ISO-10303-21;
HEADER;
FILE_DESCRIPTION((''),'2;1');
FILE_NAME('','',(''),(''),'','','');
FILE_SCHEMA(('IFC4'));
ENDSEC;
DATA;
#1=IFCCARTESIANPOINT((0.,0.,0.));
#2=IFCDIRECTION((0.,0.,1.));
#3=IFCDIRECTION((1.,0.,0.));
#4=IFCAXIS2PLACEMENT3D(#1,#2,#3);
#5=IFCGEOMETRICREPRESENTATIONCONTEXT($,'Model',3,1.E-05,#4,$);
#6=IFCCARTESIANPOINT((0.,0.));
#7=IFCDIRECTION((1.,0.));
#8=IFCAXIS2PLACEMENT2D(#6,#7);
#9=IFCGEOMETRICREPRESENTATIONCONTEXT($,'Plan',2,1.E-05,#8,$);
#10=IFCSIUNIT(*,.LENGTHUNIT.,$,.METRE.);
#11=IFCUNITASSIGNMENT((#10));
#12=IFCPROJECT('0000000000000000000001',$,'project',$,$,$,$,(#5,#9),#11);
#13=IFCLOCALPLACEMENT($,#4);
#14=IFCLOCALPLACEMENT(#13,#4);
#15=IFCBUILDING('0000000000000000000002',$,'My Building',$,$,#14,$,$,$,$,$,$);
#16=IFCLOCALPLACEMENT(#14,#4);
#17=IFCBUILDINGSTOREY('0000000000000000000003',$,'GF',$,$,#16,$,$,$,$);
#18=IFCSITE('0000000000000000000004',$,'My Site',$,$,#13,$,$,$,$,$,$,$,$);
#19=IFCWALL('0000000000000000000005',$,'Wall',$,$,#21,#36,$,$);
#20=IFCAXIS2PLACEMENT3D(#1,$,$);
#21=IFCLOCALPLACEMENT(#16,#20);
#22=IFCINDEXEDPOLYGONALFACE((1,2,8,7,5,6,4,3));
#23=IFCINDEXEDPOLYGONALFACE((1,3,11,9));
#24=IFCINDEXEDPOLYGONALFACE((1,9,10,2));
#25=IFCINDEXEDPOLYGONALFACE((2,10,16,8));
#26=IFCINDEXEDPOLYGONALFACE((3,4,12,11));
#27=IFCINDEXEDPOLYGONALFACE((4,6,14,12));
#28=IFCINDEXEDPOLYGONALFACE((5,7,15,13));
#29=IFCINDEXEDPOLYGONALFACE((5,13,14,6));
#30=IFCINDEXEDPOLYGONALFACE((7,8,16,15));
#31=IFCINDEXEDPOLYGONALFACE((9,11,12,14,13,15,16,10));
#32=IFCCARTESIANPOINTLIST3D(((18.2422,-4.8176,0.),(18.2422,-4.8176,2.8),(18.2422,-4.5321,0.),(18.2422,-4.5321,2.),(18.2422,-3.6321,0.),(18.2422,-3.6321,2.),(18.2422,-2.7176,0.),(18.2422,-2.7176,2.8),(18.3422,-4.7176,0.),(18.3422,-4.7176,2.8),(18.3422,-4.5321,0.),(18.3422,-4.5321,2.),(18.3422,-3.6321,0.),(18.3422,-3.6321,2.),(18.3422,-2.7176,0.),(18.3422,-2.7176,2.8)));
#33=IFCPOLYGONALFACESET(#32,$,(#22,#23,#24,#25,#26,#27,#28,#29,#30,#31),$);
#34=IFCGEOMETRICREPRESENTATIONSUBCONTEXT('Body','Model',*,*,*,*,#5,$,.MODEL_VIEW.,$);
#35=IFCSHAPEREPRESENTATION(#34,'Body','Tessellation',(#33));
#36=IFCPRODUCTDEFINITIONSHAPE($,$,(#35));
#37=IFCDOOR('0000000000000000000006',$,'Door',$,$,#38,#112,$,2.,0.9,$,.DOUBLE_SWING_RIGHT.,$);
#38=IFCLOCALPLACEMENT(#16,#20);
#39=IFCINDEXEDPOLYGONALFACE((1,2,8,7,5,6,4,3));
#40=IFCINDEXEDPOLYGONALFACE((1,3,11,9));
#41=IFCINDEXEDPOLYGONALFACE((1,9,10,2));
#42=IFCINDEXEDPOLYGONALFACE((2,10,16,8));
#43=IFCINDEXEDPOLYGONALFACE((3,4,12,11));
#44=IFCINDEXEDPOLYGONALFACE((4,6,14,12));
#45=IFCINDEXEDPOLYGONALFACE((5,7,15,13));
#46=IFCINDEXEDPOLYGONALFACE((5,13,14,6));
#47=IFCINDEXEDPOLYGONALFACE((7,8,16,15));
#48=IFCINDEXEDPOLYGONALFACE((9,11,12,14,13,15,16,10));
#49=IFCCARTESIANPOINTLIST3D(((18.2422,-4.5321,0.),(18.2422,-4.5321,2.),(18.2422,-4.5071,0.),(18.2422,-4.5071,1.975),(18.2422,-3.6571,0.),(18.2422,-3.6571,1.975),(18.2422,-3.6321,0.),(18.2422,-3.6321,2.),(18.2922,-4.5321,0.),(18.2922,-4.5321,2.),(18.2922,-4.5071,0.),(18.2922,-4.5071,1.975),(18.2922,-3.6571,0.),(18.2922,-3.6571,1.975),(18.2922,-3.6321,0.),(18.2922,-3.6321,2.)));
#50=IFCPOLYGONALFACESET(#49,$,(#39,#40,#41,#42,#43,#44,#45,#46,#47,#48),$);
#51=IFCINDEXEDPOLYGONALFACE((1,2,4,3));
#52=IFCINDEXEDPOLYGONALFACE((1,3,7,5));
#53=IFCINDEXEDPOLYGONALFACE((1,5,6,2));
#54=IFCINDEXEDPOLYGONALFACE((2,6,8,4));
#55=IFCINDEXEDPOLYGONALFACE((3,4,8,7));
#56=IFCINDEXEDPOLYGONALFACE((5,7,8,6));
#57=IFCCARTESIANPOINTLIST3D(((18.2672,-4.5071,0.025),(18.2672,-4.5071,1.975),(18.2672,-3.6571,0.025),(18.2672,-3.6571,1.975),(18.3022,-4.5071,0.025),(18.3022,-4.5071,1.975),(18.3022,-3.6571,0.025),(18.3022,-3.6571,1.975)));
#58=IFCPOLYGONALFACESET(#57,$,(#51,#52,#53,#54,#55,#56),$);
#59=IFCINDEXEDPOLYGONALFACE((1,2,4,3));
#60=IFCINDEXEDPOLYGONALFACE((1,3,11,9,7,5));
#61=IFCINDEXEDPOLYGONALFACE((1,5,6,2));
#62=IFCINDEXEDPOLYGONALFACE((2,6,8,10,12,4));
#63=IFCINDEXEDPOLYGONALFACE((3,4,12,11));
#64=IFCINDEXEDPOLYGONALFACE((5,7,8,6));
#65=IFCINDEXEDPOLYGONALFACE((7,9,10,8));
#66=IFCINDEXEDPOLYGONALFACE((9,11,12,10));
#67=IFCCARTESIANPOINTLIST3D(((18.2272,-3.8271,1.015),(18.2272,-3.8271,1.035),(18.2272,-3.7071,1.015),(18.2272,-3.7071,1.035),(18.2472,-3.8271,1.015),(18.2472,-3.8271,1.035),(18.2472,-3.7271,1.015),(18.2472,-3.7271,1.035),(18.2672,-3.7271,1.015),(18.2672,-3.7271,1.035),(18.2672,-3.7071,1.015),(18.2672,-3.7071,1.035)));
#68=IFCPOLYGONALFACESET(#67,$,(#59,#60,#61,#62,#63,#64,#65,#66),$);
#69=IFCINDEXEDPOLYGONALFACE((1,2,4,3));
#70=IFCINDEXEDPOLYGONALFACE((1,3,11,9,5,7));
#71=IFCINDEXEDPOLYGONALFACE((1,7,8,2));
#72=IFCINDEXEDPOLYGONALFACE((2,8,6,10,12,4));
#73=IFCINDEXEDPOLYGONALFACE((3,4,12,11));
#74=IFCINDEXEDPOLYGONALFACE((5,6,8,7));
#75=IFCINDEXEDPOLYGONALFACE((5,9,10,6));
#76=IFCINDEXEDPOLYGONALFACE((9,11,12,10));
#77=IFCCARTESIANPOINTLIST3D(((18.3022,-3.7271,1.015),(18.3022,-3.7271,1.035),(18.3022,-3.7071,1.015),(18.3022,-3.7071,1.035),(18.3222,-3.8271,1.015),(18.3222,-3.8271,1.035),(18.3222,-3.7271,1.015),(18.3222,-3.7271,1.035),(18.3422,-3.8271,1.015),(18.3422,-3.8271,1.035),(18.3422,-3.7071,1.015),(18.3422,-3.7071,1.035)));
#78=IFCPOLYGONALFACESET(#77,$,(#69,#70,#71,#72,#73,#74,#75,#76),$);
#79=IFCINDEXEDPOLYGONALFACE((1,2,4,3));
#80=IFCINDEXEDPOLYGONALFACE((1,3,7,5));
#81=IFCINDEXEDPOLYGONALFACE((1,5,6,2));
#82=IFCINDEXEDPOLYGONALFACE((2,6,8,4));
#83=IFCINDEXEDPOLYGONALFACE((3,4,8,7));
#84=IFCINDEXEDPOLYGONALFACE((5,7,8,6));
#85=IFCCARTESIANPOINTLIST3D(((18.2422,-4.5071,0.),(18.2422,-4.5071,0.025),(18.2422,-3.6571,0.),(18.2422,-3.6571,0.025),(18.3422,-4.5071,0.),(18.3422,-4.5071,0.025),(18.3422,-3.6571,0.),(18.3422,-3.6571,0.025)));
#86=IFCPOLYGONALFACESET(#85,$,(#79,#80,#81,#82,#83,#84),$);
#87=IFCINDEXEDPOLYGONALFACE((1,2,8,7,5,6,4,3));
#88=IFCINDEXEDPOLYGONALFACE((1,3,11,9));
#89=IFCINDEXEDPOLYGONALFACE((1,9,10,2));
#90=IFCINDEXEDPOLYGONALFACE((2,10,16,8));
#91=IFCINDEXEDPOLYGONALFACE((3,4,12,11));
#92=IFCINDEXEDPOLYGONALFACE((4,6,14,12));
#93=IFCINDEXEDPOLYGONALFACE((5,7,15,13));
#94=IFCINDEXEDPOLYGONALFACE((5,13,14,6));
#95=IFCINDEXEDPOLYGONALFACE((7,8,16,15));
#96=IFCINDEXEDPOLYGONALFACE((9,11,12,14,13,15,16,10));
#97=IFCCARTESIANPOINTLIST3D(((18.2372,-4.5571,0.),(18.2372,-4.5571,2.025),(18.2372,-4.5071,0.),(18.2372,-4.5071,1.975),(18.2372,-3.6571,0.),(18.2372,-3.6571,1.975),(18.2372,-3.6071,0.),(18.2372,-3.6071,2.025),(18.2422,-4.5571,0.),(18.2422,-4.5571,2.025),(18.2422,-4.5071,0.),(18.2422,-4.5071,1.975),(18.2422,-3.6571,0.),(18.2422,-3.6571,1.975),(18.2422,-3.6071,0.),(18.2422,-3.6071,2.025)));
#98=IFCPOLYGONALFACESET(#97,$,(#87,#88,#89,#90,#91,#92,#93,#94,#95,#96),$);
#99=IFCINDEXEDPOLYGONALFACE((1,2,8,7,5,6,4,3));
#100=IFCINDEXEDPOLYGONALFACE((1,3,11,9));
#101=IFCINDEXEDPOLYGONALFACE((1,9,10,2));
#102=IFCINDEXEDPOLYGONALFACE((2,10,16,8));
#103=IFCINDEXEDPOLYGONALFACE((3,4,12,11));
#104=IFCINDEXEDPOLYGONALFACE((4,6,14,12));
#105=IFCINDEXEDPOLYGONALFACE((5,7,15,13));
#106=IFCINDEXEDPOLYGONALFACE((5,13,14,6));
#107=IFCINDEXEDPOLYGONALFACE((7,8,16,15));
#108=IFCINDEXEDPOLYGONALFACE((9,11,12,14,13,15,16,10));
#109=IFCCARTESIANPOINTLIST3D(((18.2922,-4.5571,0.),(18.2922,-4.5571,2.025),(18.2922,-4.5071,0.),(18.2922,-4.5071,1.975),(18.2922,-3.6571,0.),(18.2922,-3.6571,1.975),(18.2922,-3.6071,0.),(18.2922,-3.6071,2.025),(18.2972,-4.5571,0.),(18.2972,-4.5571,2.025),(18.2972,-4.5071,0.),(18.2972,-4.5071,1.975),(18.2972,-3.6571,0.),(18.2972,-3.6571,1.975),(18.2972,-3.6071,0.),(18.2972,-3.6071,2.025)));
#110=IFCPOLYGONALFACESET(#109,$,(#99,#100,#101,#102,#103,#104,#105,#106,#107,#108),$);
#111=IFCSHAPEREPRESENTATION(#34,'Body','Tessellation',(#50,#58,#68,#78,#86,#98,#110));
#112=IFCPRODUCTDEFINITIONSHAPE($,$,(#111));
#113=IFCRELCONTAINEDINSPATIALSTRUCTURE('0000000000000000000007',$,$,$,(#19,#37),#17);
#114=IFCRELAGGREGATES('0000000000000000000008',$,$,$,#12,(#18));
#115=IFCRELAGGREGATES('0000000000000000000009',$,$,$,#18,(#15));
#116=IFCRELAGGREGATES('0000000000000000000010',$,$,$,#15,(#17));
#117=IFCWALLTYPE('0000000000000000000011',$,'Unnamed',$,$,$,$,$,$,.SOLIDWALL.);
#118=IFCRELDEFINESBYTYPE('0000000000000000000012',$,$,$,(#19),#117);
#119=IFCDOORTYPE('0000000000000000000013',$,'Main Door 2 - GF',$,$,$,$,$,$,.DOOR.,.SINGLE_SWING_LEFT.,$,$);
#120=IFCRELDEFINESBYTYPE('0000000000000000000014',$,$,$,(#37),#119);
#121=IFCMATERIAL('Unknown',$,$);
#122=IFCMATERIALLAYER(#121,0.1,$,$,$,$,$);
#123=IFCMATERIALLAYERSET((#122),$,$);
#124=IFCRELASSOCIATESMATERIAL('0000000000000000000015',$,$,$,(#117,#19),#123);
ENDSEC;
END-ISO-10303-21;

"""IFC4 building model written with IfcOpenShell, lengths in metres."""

from ifc_helpers import new_model, entity, si_unit, frame, origin_with_axes, origin_2d_with_axis, place, context, subcontext, project, spatial, line, indexed_curve, outline, extrude, shape, source, transform, mapped, material, layer, layer_set, layer_usage, type_object, type_shapes, element, fill, save


model = new_model("IFC4")

# Units and contexts
model_context = context("Model", 3, precision=1e-05, world=origin_with_axes())
plan_context = context("Plan", 2, precision=1e-05, world=origin_2d_with_axis())
body_context_1 = subcontext(model_context, "Body", "Model", "MODEL_VIEW")
body_context_2 = subcontext(plan_context, "Body", "Plan", "PLAN_VIEW")
ifc_project = project(units=[si_unit("LENGTHUNIT", "METRE")], contexts=[model_context, plan_context])

# Site, building, storey
site_placement = place(None, origin_with_axes())
site = spatial("IfcSite", under=ifc_project, at=site_placement, Name="My Site")
building_placement = place(site_placement, origin_with_axes())
building = spatial("IfcBuilding", under=site, at=building_placement, Name="My Building")
storey_placement = place(building_placement, origin_with_axes())
storey = spatial("IfcBuildingStorey", under=building, at=storey_placement, Name="GF")

# Shared definitions
ifc_material = material(Name="Unknown")

# Shared definitions
ifc_layer_1 = layer(ifc_material, 0.1)
ifc_layer_set_1 = layer_set([ifc_layer_1])
wall_type = type_object("IfcWallType", Name="Unnamed", PredefinedType="SOLIDWALL", material=ifc_layer_set_1)

# Wall, opening, door
ifc_layer_usage_1 = layer_usage(ifc_layer_set_1, "AXIS2", "POSITIVE", 0.0)
wall_1_placement = place(storey_placement, frame((18.3422, -4.7176, 0.0), z_axis=(0.0, 0.0, 1.0), x_axis=(0.0, 1.0, 0.0)))
wall_1 = element("IfcWall", 1, at=wall_1_placement, inside=storey, type_object=wall_type, material=ifc_layer_usage_1, Name="Wall", context=body_context_1, shape_type="SweptSolid", body=[
    extrude(outline(indexed_curve([(0.0, 0.0), (-0.1, 0.1), (2.0, 0.1), (2.0, 0.0)], segments=[line(1, 2, 3, 4, 1)])), origin_with_axes(), (0.0, 0.0, 1.0), 2.8),
])
shared_shape_1 = source(origin_with_axes(), body_context_1, "Body", "SweptSolid", [
    extrude(outline(indexed_curve([(0.0, 0.0), (0.9, 0.0), (0.9, 2.0), (0.0, 2.0)], segments=[line(1, 2, 3, 4, 1)])), frame((0.0, -0.6, 0.0), z_axis=(0.0, -1.0, 0.0), x_axis=(1.0, 0.0, 0.0)), (0.0, 0.0, -1.0), 1.2),
])
opening_1_placement = place(wall_1_placement, frame((1.0855, 0.1, 0.0), z_axis=(0.0, 0.0, 1.0), x_axis=(-1.0, 0.0, 0.0)))
opening_1 = element("IfcOpeningElement", 2, at=opening_1_placement, cuts=wall_1, PredefinedType="OPENING", context=body_context_1, shape_type="MappedRepresentation", body=[
    mapped(shared_shape_1, transform((0.0, 0.0, 0.0), x_axis=(1.0, 0.0, 0.0), y_axis=(0.0, 1.0, 0.0), z_axis=(0.0, 0.0, 1.0), scale=1.0)),
])
door_type_1 = type_object("IfcDoorType", Name="Main Door 2 - GF", OperationType="SINGLE_SWING_LEFT", PredefinedType="DOOR")
shared_shape_2 = source(origin_with_axes(), body_context_1, "Body", "SweptSolid", [
    extrude(outline(indexed_curve([(0.0, 0.0), (0.0, 2.0), (0.9, 2.0), (0.9, 0.0), (0.875, 0.0), (0.875, 1.975), (0.025, 1.975), (0.025, 0.0)], segments=[line(1, 2, 3, 4, 5, 6, 7, 8, 1)])), frame((0.0, 0.0, 0.0), z_axis=(0.0, -1.0, 0.0), x_axis=(1.0, 0.0, 0.0)), (0.0, 0.0, -1.0), 0.05),
    extrude(outline(indexed_curve([(0.0, 0.0), (0.85, 0.0), (0.85, 0.035), (0.0, 0.035)], segments=[line(1, 2, 3, 4, 1)])), frame((0.025, 0.025, 0.025), z_axis=(0.0, 0.0, 1.0), x_axis=(1.0, 0.0, 0.0)), (0.0, 0.0, 1.0), 1.95),
    extrude(outline(indexed_curve([(0.0, 0.0), (0.0, -0.04), (0.12, -0.04), (0.12, -0.02), (0.02, -0.02), (0.02, 0.0)], segments=[line(1, 2, 3, 4, 5, 6, 1)])), frame((0.075, 0.025, 1.015), z_axis=(0.0, 0.0, 1.0), x_axis=(1.0, 0.0, 0.0)), (0.0, 0.0, 1.0), 0.02),
    extrude(outline(indexed_curve([(0.0, 0.0), (0.0, 0.04), (0.12, 0.04), (0.12, 0.02), (0.02, 0.02), (0.02, 0.0)], segments=[line(1, 2, 3, 4, 5, 6, 1)])), frame((0.075, 0.06, 1.015), z_axis=(0.0, 0.0, 1.0), x_axis=(1.0, 0.0, 0.0)), (0.0, 0.0, 1.0), 0.02),
    extrude(outline(indexed_curve([(0.0, 0.0), (0.85, 0.0), (0.85, 0.1), (0.0, 0.1)], segments=[line(1, 2, 3, 4, 1)])), frame((0.025, 0.0, 0.0), z_axis=(0.0, 0.0, 1.0), x_axis=(1.0, 0.0, 0.0)), (0.0, 0.0, 1.0), 0.025),
    extrude(outline(indexed_curve([(0.0, 0.0), (0.0, 2.025), (0.95, 2.025), (0.95, 0.0), (0.9, 0.0), (0.9, 1.975), (0.05, 1.975), (0.05, 0.0)], segments=[line(1, 2, 3, 4, 5, 6, 7, 8, 1)])), frame((-0.025, -0.005, 0.0), z_axis=(0.0, -1.0, 0.0), x_axis=(1.0, 0.0, 0.0)), (0.0, 0.0, -1.0), 0.005),
    extrude(outline(indexed_curve([(0.0, 0.0), (0.0, 2.025), (0.95, 2.025), (0.95, 0.0), (0.9, 0.0), (0.9, 1.975), (0.05, 1.975), (0.05, 0.0)], segments=[line(1, 2, 3, 4, 5, 6, 7, 8, 1)])), frame((-0.025, 0.05, 0.0), z_axis=(0.0, -1.0, 0.0), x_axis=(1.0, 0.0, 0.0)), (0.0, 0.0, -1.0), 0.005),
])
shared_shape_3 = source(origin_with_axes(), body_context_2, "Body", "Curve2D", [
    entity("IfcIndexedPolyCurve", entity("IfcCartesianPointList2D", [[0.0, 0.0], [0.025, 0.0], [0.025, 0.05], [0.0, 0.05]]), [entity("IfcLineIndex", [1, 2, 3, 4, 1])]),
    entity("IfcIndexedPolyCurve", entity("IfcCartesianPointList2D", [[0.9, 0.0], [0.875, 0.0], [0.875, 0.05], [0.9, 0.05]]), [entity("IfcLineIndex", [1, 2, 3, 4, 1])]),
    entity("IfcIndexedPolyCurve", entity("IfcCartesianPointList2D", [[0.875, 0.05], [0.875, -0.8], [0.84, -0.8]])),
    entity("IfcTrimmedCurve", entity("IfcEllipse", entity("IfcAxis2Placement2D", entity("IfcCartesianPoint", [0.84, 0.05]), entity("IfcDirection", [1.0, 0.0])), 0.815, 0.85), [entity("IfcCartesianPoint", [0.84, 0.9])], [entity("IfcCartesianPoint", [0.84, -0.8])], True, "CARTESIAN"),
    entity("IfcIndexedPolyCurve", entity("IfcCartesianPointList2D", [[0.875, 0.05], [0.84, 0.05], [0.84, 0.9], [0.875, 0.9]]), [entity("IfcLineIndex", [1, 2, 3, 4, 1])]),
])
type_shapes(door_type_1, [shared_shape_2, shared_shape_3])
door_1_placement = place(opening_1_placement, frame((0.0, 0.0, 0.0), z_axis=(0.0, 0.0, 1.0), x_axis=(1.0, 0.0, 0.0)))
door_1 = element("IfcDoor", 3, at=door_1_placement, inside=storey, type_object=door_type_1, Name="Door", OperationType="DOUBLE_SWING_RIGHT", OverallHeight=2.0, OverallWidth=0.9, shapes=[
    shape(body_context_1, "Body", "MappedRepresentation", [mapped(shared_shape_2, transform((0.0, 0.0, 0.0), x_axis=(1.0, 0.0, 0.0), y_axis=(0.0, 1.0, 0.0), z_axis=(0.0, 0.0, 1.0), scale=1.0))]),
    shape(body_context_2, "Body", "MappedRepresentation", [mapped(shared_shape_3, transform((0.0, 0.0, 0.0), x_axis=(1.0, 0.0, 0.0), y_axis=(0.0, 1.0, 0.0), z_axis=(0.0, 0.0, 1.0), scale=1.0))]),
])
fill(opening_1, door_1)

save(model, "model.ifc")
